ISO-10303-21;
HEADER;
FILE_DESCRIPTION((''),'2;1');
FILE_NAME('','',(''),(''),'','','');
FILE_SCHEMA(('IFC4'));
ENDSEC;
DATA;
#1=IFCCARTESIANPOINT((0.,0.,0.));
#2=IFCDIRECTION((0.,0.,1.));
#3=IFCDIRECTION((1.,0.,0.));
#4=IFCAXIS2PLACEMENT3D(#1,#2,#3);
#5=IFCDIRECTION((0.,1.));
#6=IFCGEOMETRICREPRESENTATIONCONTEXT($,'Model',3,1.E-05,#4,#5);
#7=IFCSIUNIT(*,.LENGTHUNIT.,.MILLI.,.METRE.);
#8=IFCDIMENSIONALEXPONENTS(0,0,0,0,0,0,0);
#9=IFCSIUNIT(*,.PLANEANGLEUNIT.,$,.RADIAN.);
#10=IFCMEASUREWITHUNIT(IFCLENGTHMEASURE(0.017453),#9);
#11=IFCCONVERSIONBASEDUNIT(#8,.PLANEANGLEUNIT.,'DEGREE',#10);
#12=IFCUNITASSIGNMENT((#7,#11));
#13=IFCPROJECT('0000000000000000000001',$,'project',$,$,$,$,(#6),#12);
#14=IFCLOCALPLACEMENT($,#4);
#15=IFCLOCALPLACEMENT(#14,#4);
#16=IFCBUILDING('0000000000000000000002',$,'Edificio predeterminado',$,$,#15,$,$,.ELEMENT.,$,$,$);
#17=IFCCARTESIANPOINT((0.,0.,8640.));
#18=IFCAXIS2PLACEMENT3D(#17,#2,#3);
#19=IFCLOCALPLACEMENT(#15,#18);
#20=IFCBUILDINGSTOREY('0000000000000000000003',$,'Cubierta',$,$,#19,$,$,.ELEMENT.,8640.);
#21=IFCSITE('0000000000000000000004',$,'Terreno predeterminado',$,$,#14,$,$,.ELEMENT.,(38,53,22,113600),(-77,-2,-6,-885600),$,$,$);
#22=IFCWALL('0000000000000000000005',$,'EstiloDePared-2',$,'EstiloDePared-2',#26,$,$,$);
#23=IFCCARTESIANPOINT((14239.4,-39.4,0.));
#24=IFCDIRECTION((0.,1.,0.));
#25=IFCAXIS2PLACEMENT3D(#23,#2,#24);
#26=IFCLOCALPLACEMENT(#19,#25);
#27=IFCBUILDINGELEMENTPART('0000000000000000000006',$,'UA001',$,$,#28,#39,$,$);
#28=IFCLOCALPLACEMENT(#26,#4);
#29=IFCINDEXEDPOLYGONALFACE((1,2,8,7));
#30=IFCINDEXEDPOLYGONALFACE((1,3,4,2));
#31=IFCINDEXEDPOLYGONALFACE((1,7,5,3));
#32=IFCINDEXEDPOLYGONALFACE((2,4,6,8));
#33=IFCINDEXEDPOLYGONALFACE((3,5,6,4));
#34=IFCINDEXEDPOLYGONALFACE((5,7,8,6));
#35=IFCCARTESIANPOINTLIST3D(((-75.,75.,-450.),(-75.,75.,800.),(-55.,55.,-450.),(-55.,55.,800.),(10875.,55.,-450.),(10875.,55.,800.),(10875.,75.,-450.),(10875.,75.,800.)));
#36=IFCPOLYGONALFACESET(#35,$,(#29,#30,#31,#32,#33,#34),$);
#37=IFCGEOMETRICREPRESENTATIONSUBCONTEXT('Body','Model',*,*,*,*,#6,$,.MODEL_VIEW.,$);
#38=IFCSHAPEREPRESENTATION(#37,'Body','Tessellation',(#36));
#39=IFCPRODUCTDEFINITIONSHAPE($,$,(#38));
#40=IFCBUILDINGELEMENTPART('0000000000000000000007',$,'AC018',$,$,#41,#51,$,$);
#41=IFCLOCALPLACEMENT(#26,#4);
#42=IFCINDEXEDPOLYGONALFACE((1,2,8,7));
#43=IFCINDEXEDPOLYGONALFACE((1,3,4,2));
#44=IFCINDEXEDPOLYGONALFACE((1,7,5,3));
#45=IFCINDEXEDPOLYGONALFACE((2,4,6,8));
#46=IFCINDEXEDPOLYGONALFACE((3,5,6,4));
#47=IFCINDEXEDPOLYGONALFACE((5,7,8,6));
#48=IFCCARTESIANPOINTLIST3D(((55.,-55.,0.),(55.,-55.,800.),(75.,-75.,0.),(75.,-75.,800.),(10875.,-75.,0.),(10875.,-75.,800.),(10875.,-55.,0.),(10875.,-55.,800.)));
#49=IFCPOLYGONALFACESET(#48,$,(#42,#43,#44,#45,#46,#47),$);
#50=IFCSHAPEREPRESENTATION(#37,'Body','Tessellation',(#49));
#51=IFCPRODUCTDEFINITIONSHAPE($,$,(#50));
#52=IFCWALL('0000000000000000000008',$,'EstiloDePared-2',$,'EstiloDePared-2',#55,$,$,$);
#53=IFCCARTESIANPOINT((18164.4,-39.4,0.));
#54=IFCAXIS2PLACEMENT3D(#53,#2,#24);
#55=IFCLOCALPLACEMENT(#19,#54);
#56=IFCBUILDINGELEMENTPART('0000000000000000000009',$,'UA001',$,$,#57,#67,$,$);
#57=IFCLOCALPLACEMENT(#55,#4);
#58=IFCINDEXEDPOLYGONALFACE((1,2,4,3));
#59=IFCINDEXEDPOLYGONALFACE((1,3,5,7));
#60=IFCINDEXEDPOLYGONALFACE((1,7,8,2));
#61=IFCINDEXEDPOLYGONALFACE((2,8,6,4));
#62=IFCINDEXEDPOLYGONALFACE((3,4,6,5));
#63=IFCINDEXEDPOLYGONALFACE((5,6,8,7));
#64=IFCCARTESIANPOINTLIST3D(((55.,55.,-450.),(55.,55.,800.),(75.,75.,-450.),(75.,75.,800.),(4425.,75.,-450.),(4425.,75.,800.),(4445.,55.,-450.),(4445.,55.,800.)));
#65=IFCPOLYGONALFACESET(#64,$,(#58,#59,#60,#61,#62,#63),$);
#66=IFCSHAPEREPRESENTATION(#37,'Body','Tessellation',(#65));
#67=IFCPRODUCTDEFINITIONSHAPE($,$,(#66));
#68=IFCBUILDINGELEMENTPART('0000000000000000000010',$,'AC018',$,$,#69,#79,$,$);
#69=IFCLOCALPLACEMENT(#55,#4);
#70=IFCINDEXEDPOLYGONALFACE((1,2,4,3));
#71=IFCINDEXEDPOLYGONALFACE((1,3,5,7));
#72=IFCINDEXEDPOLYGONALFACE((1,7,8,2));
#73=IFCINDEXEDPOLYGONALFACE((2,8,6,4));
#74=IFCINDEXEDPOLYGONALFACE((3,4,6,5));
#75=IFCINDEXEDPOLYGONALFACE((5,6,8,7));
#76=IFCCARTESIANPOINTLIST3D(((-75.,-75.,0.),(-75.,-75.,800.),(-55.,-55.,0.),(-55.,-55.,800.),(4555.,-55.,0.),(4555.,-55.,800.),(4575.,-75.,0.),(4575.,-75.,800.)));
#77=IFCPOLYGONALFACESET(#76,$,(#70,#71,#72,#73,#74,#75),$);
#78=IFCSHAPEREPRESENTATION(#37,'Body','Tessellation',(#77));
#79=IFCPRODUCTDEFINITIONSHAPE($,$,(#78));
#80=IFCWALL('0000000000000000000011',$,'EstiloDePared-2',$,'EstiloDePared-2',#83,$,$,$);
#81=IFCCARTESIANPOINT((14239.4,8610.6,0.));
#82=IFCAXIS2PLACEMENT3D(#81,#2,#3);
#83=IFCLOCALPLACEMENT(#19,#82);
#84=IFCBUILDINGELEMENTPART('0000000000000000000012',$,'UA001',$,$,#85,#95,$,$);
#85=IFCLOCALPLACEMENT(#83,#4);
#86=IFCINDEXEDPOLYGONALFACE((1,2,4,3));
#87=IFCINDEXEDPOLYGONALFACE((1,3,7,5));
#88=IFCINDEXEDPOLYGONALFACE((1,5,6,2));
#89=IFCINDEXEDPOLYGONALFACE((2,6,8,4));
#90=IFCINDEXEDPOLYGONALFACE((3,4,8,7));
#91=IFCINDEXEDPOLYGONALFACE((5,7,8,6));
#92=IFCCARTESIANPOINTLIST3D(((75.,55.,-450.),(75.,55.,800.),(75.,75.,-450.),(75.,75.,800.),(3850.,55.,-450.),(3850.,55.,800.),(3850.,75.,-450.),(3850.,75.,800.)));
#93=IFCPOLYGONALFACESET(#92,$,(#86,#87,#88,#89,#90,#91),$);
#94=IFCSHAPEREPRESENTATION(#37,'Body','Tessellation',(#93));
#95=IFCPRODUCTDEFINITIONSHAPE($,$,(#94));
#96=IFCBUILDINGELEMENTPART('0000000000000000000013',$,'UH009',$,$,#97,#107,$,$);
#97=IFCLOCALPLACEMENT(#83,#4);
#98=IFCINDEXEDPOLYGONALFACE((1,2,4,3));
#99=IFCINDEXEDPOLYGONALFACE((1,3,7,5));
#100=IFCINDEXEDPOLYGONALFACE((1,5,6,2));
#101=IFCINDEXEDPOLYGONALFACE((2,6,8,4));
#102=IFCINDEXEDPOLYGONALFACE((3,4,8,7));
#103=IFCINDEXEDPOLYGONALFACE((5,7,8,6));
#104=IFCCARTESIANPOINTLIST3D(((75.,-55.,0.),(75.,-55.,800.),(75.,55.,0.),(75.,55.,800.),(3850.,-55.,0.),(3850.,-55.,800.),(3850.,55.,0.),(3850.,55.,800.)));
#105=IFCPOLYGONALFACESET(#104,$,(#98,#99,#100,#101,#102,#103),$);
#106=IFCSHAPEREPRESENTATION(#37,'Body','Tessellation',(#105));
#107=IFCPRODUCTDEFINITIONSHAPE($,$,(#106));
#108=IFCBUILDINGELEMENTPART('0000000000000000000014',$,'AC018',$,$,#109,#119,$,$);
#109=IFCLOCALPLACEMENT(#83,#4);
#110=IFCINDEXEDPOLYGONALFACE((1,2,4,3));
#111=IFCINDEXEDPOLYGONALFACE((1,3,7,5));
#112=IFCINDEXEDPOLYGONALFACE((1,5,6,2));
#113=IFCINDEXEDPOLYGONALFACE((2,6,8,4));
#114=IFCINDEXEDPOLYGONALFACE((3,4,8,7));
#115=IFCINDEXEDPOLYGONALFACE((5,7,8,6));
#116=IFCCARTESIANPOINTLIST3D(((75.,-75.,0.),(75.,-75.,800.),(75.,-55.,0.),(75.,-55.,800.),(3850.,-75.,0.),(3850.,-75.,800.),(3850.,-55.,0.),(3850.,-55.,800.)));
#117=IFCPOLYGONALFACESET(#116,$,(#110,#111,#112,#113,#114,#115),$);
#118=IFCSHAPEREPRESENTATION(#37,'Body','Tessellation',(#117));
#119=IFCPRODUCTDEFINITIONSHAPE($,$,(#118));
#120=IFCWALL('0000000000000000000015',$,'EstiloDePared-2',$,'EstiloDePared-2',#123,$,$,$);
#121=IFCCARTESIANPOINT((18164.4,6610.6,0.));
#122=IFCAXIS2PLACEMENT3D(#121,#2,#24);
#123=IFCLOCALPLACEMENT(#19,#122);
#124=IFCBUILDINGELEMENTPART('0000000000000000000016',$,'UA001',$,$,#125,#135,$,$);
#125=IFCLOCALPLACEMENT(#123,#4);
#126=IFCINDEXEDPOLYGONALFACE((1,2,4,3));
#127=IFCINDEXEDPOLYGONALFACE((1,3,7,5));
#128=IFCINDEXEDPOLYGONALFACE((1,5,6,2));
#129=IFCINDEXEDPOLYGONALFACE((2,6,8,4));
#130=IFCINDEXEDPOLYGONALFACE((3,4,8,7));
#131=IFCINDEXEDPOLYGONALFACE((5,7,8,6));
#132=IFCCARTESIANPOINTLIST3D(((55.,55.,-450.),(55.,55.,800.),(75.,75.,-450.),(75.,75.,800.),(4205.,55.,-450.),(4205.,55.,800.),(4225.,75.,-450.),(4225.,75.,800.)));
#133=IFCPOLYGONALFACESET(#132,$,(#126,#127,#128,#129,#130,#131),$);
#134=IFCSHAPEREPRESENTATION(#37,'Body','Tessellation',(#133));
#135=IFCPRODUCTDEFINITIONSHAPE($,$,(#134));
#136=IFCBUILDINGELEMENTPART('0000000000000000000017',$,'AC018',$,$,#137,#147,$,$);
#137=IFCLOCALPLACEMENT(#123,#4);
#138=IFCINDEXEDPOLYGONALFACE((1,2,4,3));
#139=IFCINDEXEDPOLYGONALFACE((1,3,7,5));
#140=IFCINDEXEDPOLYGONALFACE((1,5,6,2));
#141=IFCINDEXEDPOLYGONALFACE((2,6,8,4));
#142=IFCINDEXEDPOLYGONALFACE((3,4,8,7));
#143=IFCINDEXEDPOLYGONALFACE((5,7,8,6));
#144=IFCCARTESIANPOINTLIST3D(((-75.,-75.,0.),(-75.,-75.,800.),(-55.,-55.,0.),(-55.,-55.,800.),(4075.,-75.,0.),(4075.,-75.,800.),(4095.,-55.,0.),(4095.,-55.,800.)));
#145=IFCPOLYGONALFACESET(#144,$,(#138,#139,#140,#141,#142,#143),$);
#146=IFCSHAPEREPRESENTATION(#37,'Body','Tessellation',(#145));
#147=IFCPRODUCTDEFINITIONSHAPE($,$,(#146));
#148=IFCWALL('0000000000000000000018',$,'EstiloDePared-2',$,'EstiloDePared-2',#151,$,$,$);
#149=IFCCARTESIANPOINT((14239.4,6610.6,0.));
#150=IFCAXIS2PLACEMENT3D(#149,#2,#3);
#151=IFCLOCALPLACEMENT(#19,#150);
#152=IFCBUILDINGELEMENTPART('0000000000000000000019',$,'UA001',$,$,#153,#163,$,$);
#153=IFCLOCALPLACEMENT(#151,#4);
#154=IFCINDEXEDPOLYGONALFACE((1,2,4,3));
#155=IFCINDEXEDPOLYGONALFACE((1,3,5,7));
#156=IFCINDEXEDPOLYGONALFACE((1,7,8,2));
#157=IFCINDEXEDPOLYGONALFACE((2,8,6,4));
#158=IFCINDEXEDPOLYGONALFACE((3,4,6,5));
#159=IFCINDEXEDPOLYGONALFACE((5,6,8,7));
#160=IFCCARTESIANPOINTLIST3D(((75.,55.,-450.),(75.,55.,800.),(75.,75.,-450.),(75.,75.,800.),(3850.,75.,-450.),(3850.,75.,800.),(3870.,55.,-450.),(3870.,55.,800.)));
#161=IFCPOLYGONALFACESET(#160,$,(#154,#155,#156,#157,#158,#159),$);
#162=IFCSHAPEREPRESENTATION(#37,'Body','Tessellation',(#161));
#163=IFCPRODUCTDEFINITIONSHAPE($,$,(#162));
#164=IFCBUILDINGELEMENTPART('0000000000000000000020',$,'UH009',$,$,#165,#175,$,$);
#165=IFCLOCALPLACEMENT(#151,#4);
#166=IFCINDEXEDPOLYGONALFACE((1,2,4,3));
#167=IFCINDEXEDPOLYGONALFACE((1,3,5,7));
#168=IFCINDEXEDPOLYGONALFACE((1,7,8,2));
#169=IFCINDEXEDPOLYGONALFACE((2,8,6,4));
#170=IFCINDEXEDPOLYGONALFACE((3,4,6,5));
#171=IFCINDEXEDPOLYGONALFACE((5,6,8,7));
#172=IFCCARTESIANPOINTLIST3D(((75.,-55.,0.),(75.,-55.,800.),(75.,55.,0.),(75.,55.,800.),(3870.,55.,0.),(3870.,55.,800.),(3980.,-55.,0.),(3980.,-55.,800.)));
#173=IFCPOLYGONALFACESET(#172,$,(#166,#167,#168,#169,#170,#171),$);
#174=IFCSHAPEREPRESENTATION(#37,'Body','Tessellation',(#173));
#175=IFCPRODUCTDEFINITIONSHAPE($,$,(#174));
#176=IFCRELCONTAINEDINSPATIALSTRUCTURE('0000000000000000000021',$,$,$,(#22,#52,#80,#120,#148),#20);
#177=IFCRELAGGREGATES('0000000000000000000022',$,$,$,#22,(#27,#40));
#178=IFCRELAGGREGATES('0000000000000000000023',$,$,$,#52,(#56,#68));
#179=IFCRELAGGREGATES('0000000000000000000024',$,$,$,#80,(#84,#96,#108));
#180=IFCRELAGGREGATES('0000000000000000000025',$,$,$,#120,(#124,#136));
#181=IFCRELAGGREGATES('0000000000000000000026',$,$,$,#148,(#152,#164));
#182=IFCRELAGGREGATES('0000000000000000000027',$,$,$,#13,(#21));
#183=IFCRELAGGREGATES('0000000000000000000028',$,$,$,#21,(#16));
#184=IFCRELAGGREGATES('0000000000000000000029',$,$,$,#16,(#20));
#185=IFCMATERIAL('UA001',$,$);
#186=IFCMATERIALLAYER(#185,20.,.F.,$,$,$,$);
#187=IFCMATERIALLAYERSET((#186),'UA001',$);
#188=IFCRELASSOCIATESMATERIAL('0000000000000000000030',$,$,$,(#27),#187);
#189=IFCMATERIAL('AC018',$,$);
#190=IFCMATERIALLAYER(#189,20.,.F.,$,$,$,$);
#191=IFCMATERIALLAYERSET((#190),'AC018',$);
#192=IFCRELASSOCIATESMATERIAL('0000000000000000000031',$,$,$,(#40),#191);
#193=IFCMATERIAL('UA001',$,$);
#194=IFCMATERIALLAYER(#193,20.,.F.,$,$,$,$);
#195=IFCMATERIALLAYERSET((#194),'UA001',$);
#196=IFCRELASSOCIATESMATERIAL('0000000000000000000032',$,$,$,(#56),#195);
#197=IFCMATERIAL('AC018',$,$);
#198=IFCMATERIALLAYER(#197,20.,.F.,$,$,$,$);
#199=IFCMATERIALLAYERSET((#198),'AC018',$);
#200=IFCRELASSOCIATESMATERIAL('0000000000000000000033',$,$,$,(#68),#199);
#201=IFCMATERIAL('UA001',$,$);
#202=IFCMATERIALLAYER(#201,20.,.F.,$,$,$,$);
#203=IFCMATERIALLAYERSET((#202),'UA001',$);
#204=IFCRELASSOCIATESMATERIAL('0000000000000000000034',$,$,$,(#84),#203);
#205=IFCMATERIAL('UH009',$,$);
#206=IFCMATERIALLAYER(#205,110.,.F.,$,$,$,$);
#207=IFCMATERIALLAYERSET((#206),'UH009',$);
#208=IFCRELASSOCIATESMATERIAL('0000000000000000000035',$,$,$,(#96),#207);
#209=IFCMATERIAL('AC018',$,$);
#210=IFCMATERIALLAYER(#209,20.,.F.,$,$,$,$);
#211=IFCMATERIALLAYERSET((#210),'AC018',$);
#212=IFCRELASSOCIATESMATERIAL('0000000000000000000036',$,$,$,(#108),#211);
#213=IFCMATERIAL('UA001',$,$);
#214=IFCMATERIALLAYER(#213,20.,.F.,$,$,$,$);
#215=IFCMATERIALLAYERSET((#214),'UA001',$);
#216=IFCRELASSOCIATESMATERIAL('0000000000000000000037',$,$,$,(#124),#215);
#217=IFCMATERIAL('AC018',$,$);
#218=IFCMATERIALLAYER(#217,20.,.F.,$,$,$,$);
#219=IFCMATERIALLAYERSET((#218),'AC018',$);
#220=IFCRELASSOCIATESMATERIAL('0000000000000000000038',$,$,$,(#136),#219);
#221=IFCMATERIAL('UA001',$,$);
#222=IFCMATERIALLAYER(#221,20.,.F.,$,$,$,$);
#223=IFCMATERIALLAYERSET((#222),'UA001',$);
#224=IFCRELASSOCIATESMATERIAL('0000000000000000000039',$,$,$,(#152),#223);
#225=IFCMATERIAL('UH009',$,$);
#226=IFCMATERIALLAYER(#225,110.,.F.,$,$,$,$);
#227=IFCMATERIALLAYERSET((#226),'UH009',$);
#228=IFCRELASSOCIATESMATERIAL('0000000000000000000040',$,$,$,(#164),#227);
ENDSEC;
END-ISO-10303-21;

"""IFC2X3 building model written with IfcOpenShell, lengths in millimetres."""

from ifc_helpers import new_model, entity, si_unit, converted_unit, direction, frame, origin_with_axes, place, context, subcontext, project, spatial, polyline, outline, extrude, material, layer, layer_set, layer_usage, element, aggregate, save


model = new_model("IFC2X3")

# Units and contexts
model_context = context("Model", 3, precision=1e-05, world=origin_with_axes(), true_north=direction((0.0, 1.0)))
body_context = subcontext(model_context, "Body", "Model", "MODEL_VIEW")
ifc_project = project(units=[si_unit("LENGTHUNIT", "METRE", prefix="MILLI"), converted_unit("PLANEANGLEUNIT", "DEGREE", entity("IfcLengthMeasure", 0.017453), si_unit("PLANEANGLEUNIT", "RADIAN"), dimensions=[0, 0, 0, 0, 0, 0, 0])], contexts=[model_context])

# Site, building, storey
site_placement = place(None, origin_with_axes())
site = spatial("IfcSite", under=ifc_project, at=site_placement, Name="Terreno predeterminado", CompositionType="ELEMENT", RefLatitude=(38, 53, 22, 113600), RefLongitude=(-77, -2, -6, -885600))
building_placement = place(site_placement, origin_with_axes())
building = spatial("IfcBuilding", under=site, at=building_placement, Name="Edificio predeterminado", CompositionType="ELEMENT")
storey_placement = place(building_placement, frame((0.0, 0.0, 8640.0), z_axis=(0.0, 0.0, 1.0), x_axis=(1.0, 0.0, 0.0)))
storey = spatial("IfcBuildingStorey", under=building, at=storey_placement, Name="Cubierta", CompositionType="ELEMENT", Elevation=8640.0)

# Walls, building element parts
wall_1_placement = place(storey_placement, frame((14239.4, -39.4, 0.0), z_axis=(0.0, 0.0, 1.0), x_axis=(0.0, 1.0, 0.0)))
wall_1 = element("IfcWall", 1, at=wall_1_placement, inside=storey, Name="EstiloDePared-2", ObjectType="EstiloDePared-2")
ifc_material_1 = material(Name="UA001")
ifc_layer_1 = layer(ifc_material_1, 20.0, ventilated=False)
ifc_layer_set_1 = layer_set([ifc_layer_1], Name="UA001")
ifc_layer_usage_1 = layer_usage(ifc_layer_set_1, "AXIS2", "NEGATIVE", -75.0)
building_element_part_1_placement = place(wall_1_placement, origin_with_axes())
building_element_part_1 = element("IfcBuildingElementPart", 2, at=building_element_part_1_placement, material=ifc_layer_usage_1, Name="UA001", context=body_context, shape_type="SweptSolid", body=[
    extrude(outline(polyline([(10875.0, 75.0), (10875.0, 55.0), (-55.0, 55.0), (-75.0, 75.0), (10875.0, 75.0)])), frame((0.0, 0.0, -450.0), z_axis=(0.0, 0.0, 1.0), x_axis=(1.0, 0.0, 0.0)), (0.0, 0.0, 1.0), 1250.0),
])
ifc_material_2 = material(Name="AC018")
ifc_layer_2 = layer(ifc_material_2, 20.0, ventilated=False)
ifc_layer_set_2 = layer_set([ifc_layer_2], Name="AC018")
ifc_layer_usage_2 = layer_usage(ifc_layer_set_2, "AXIS2", "NEGATIVE", 55.0)
building_element_part_2_placement = place(wall_1_placement, origin_with_axes())
building_element_part_2 = element("IfcBuildingElementPart", 3, at=building_element_part_2_placement, material=ifc_layer_usage_2, Name="AC018", context=body_context, shape_type="SweptSolid", body=[
    extrude(outline(polyline([(10875.0, -55.0), (10875.0, -75.0), (75.0, -75.0), (55.0, -55.0), (10875.0, -55.0)])), origin_with_axes(), (0.0, 0.0, 1.0), 800.0),
])
aggregate(wall_1, [building_element_part_1, building_element_part_2])
wall_2_placement = place(storey_placement, frame((18164.4, -39.4, 0.0), z_axis=(0.0, 0.0, 1.0), x_axis=(0.0, 1.0, 0.0)))
wall_2 = element("IfcWall", 4, at=wall_2_placement, inside=storey, Name="EstiloDePared-2", ObjectType="EstiloDePared-2")
ifc_material_3 = material(Name="UA001")
ifc_layer_3 = layer(ifc_material_3, 20.0, ventilated=False)
ifc_layer_set_3 = layer_set([ifc_layer_3], Name="UA001")
ifc_layer_usage_3 = layer_usage(ifc_layer_set_3, "AXIS2", "NEGATIVE", -75.0)
building_element_part_3_placement = place(wall_2_placement, origin_with_axes())
building_element_part_3 = element("IfcBuildingElementPart", 5, at=building_element_part_3_placement, material=ifc_layer_usage_3, Name="UA001", context=body_context, shape_type="SweptSolid", body=[
    extrude(outline(polyline([(4425.0, 75.0), (4445.0, 55.0), (55.0, 55.0), (75.0, 75.0), (4425.0, 75.0)])), frame((0.0, 0.0, -450.0), z_axis=(0.0, 0.0, 1.0), x_axis=(1.0, 0.0, 0.0)), (0.0, 0.0, 1.0), 1250.0),
])
ifc_material_4 = material(Name="AC018")
ifc_layer_4 = layer(ifc_material_4, 20.0, ventilated=False)
ifc_layer_set_4 = layer_set([ifc_layer_4], Name="AC018")
ifc_layer_usage_4 = layer_usage(ifc_layer_set_4, "AXIS2", "NEGATIVE", 55.0)
building_element_part_4_placement = place(wall_2_placement, origin_with_axes())
building_element_part_4 = element("IfcBuildingElementPart", 6, at=building_element_part_4_placement, material=ifc_layer_usage_4, Name="AC018", context=body_context, shape_type="SweptSolid", body=[
    extrude(outline(polyline([(4555.0, -55.0), (4575.0, -75.0), (-75.0, -75.0), (-55.0, -55.0), (4555.0, -55.0)])), origin_with_axes(), (0.0, 0.0, 1.0), 800.0),
])
aggregate(wall_2, [building_element_part_3, building_element_part_4])
wall_3_placement = place(storey_placement, frame((14239.4, 8610.6, 0.0), z_axis=(0.0, 0.0, 1.0), x_axis=(1.0, 0.0, 0.0)))
wall_3 = element("IfcWall", 7, at=wall_3_placement, inside=storey, Name="EstiloDePared-2", ObjectType="EstiloDePared-2")
ifc_material_5 = material(Name="UA001")
ifc_layer_5 = layer(ifc_material_5, 20.0, ventilated=False)
ifc_layer_set_5 = layer_set([ifc_layer_5], Name="UA001")
ifc_layer_usage_5 = layer_usage(ifc_layer_set_5, "AXIS2", "NEGATIVE", -75.0)
building_element_part_5_placement = place(wall_3_placement, origin_with_axes())
building_element_part_5 = element("IfcBuildingElementPart", 8, at=building_element_part_5_placement, material=ifc_layer_usage_5, Name="UA001", context=body_context, shape_type="SweptSolid", body=[
    extrude(outline(polyline([(3850.0, 75.0), (3850.0, 55.0), (75.0, 55.0), (75.0, 75.0), (3850.0, 75.0)])), frame((0.0, 0.0, -450.0), z_axis=(0.0, 0.0, 1.0), x_axis=(1.0, 0.0, 0.0)), (0.0, 0.0, 1.0), 1250.0),
])
ifc_material_6 = material(Name="UH009")
ifc_layer_6 = layer(ifc_material_6, 110.0, ventilated=False)
ifc_layer_set_6 = layer_set([ifc_layer_6], Name="UH009")
ifc_layer_usage_6 = layer_usage(ifc_layer_set_6, "AXIS2", "NEGATIVE", -55.0)
building_element_part_6_placement = place(wall_3_placement, origin_with_axes())
building_element_part_6 = element("IfcBuildingElementPart", 9, at=building_element_part_6_placement, material=ifc_layer_usage_6, Name="UH009", context=body_context, shape_type="SweptSolid", body=[
    extrude(outline(polyline([(3850.0, 55.0), (3850.0, -55.0), (75.0, -55.0), (75.0, 55.0), (3850.0, 55.0)])), origin_with_axes(), (0.0, 0.0, 1.0), 800.0),
])
ifc_material_7 = material(Name="AC018")
ifc_layer_7 = layer(ifc_material_7, 20.0, ventilated=False)
ifc_layer_set_7 = layer_set([ifc_layer_7], Name="AC018")
ifc_layer_usage_7 = layer_usage(ifc_layer_set_7, "AXIS2", "NEGATIVE", 55.0)
building_element_part_7_placement = place(wall_3_placement, origin_with_axes())
building_element_part_7 = element("IfcBuildingElementPart", 10, at=building_element_part_7_placement, material=ifc_layer_usage_7, Name="AC018", context=body_context, shape_type="SweptSolid", body=[
    extrude(outline(polyline([(3850.0, -55.0), (3850.0, -75.0), (75.0, -75.0), (75.0, -55.0), (3850.0, -55.0)])), origin_with_axes(), (0.0, 0.0, 1.0), 800.0),
])
aggregate(wall_3, [building_element_part_5, building_element_part_6, building_element_part_7])
wall_4_placement = place(storey_placement, frame((18164.4, 6610.6, 0.0), z_axis=(0.0, 0.0, 1.0), x_axis=(0.0, 1.0, 0.0)))
wall_4 = element("IfcWall", 11, at=wall_4_placement, inside=storey, Name="EstiloDePared-2", ObjectType="EstiloDePared-2")
ifc_material_8 = material(Name="UA001")
ifc_layer_8 = layer(ifc_material_8, 20.0, ventilated=False)
ifc_layer_set_8 = layer_set([ifc_layer_8], Name="UA001")
ifc_layer_usage_8 = layer_usage(ifc_layer_set_8, "AXIS2", "NEGATIVE", -75.0)
building_element_part_8_placement = place(wall_4_placement, origin_with_axes())
building_element_part_8 = element("IfcBuildingElementPart", 12, at=building_element_part_8_placement, material=ifc_layer_usage_8, Name="UA001", context=body_context, shape_type="SweptSolid", body=[
    extrude(outline(polyline([(4225.0, 75.0), (4205.0, 55.0), (55.0, 55.0), (75.0, 75.0), (4225.0, 75.0)])), frame((0.0, 0.0, -450.0), z_axis=(0.0, 0.0, 1.0), x_axis=(1.0, 0.0, 0.0)), (0.0, 0.0, 1.0), 1250.0),
])
ifc_material_9 = material(Name="AC018")
ifc_layer_9 = layer(ifc_material_9, 20.0, ventilated=False)
ifc_layer_set_9 = layer_set([ifc_layer_9], Name="AC018")
ifc_layer_usage_9 = layer_usage(ifc_layer_set_9, "AXIS2", "NEGATIVE", 55.0)
building_element_part_9_placement = place(wall_4_placement, origin_with_axes())
building_element_part_9 = element("IfcBuildingElementPart", 13, at=building_element_part_9_placement, material=ifc_layer_usage_9, Name="AC018", context=body_context, shape_type="SweptSolid", body=[
    extrude(outline(polyline([(4095.0, -55.0), (4075.0, -75.0), (-75.0, -75.0), (-55.0, -55.0), (4095.0, -55.0)])), origin_with_axes(), (0.0, 0.0, 1.0), 800.0),
])
aggregate(wall_4, [building_element_part_8, building_element_part_9])
wall_5_placement = place(storey_placement, frame((14239.4, 6610.6, 0.0), z_axis=(0.0, 0.0, 1.0), x_axis=(1.0, 0.0, 0.0)))
wall_5 = element("IfcWall", 14, at=wall_5_placement, inside=storey, Name="EstiloDePared-2", ObjectType="EstiloDePared-2")
ifc_material_10 = material(Name="UA001")
ifc_layer_10 = layer(ifc_material_10, 20.0, ventilated=False)
ifc_layer_set_10 = layer_set([ifc_layer_10], Name="UA001")
ifc_layer_usage_10 = layer_usage(ifc_layer_set_10, "AXIS2", "NEGATIVE", -75.0)
building_element_part_10_placement = place(wall_5_placement, origin_with_axes())
building_element_part_10 = element("IfcBuildingElementPart", 15, at=building_element_part_10_placement, material=ifc_layer_usage_10, Name="UA001", context=body_context, shape_type="SweptSolid", body=[
    extrude(outline(polyline([(3850.0, 75.0), (3870.0, 55.0), (75.0, 55.0), (75.0, 75.0), (3850.0, 75.0)])), frame((0.0, 0.0, -450.0), z_axis=(0.0, 0.0, 1.0), x_axis=(1.0, 0.0, 0.0)), (0.0, 0.0, 1.0), 1250.0),
])
ifc_material_11 = material(Name="UH009")
ifc_layer_11 = layer(ifc_material_11, 110.0, ventilated=False)
ifc_layer_set_11 = layer_set([ifc_layer_11], Name="UH009")
ifc_layer_usage_11 = layer_usage(ifc_layer_set_11, "AXIS2", "NEGATIVE", -55.0)
building_element_part_11_placement = place(wall_5_placement, origin_with_axes())
building_element_part_11 = element("IfcBuildingElementPart", 16, at=building_element_part_11_placement, material=ifc_layer_usage_11, Name="UH009", context=body_context, shape_type="SweptSolid", body=[
    extrude(outline(polyline([(3870.0, 55.0), (3980.0, -55.0), (75.0, -55.0), (75.0, 55.0), (3870.0, 55.0)])), origin_with_axes(), (0.0, 0.0, 1.0), 800.0),
])
aggregate(wall_5, [building_element_part_10, building_element_part_11])

save(model, "model.ifc")
